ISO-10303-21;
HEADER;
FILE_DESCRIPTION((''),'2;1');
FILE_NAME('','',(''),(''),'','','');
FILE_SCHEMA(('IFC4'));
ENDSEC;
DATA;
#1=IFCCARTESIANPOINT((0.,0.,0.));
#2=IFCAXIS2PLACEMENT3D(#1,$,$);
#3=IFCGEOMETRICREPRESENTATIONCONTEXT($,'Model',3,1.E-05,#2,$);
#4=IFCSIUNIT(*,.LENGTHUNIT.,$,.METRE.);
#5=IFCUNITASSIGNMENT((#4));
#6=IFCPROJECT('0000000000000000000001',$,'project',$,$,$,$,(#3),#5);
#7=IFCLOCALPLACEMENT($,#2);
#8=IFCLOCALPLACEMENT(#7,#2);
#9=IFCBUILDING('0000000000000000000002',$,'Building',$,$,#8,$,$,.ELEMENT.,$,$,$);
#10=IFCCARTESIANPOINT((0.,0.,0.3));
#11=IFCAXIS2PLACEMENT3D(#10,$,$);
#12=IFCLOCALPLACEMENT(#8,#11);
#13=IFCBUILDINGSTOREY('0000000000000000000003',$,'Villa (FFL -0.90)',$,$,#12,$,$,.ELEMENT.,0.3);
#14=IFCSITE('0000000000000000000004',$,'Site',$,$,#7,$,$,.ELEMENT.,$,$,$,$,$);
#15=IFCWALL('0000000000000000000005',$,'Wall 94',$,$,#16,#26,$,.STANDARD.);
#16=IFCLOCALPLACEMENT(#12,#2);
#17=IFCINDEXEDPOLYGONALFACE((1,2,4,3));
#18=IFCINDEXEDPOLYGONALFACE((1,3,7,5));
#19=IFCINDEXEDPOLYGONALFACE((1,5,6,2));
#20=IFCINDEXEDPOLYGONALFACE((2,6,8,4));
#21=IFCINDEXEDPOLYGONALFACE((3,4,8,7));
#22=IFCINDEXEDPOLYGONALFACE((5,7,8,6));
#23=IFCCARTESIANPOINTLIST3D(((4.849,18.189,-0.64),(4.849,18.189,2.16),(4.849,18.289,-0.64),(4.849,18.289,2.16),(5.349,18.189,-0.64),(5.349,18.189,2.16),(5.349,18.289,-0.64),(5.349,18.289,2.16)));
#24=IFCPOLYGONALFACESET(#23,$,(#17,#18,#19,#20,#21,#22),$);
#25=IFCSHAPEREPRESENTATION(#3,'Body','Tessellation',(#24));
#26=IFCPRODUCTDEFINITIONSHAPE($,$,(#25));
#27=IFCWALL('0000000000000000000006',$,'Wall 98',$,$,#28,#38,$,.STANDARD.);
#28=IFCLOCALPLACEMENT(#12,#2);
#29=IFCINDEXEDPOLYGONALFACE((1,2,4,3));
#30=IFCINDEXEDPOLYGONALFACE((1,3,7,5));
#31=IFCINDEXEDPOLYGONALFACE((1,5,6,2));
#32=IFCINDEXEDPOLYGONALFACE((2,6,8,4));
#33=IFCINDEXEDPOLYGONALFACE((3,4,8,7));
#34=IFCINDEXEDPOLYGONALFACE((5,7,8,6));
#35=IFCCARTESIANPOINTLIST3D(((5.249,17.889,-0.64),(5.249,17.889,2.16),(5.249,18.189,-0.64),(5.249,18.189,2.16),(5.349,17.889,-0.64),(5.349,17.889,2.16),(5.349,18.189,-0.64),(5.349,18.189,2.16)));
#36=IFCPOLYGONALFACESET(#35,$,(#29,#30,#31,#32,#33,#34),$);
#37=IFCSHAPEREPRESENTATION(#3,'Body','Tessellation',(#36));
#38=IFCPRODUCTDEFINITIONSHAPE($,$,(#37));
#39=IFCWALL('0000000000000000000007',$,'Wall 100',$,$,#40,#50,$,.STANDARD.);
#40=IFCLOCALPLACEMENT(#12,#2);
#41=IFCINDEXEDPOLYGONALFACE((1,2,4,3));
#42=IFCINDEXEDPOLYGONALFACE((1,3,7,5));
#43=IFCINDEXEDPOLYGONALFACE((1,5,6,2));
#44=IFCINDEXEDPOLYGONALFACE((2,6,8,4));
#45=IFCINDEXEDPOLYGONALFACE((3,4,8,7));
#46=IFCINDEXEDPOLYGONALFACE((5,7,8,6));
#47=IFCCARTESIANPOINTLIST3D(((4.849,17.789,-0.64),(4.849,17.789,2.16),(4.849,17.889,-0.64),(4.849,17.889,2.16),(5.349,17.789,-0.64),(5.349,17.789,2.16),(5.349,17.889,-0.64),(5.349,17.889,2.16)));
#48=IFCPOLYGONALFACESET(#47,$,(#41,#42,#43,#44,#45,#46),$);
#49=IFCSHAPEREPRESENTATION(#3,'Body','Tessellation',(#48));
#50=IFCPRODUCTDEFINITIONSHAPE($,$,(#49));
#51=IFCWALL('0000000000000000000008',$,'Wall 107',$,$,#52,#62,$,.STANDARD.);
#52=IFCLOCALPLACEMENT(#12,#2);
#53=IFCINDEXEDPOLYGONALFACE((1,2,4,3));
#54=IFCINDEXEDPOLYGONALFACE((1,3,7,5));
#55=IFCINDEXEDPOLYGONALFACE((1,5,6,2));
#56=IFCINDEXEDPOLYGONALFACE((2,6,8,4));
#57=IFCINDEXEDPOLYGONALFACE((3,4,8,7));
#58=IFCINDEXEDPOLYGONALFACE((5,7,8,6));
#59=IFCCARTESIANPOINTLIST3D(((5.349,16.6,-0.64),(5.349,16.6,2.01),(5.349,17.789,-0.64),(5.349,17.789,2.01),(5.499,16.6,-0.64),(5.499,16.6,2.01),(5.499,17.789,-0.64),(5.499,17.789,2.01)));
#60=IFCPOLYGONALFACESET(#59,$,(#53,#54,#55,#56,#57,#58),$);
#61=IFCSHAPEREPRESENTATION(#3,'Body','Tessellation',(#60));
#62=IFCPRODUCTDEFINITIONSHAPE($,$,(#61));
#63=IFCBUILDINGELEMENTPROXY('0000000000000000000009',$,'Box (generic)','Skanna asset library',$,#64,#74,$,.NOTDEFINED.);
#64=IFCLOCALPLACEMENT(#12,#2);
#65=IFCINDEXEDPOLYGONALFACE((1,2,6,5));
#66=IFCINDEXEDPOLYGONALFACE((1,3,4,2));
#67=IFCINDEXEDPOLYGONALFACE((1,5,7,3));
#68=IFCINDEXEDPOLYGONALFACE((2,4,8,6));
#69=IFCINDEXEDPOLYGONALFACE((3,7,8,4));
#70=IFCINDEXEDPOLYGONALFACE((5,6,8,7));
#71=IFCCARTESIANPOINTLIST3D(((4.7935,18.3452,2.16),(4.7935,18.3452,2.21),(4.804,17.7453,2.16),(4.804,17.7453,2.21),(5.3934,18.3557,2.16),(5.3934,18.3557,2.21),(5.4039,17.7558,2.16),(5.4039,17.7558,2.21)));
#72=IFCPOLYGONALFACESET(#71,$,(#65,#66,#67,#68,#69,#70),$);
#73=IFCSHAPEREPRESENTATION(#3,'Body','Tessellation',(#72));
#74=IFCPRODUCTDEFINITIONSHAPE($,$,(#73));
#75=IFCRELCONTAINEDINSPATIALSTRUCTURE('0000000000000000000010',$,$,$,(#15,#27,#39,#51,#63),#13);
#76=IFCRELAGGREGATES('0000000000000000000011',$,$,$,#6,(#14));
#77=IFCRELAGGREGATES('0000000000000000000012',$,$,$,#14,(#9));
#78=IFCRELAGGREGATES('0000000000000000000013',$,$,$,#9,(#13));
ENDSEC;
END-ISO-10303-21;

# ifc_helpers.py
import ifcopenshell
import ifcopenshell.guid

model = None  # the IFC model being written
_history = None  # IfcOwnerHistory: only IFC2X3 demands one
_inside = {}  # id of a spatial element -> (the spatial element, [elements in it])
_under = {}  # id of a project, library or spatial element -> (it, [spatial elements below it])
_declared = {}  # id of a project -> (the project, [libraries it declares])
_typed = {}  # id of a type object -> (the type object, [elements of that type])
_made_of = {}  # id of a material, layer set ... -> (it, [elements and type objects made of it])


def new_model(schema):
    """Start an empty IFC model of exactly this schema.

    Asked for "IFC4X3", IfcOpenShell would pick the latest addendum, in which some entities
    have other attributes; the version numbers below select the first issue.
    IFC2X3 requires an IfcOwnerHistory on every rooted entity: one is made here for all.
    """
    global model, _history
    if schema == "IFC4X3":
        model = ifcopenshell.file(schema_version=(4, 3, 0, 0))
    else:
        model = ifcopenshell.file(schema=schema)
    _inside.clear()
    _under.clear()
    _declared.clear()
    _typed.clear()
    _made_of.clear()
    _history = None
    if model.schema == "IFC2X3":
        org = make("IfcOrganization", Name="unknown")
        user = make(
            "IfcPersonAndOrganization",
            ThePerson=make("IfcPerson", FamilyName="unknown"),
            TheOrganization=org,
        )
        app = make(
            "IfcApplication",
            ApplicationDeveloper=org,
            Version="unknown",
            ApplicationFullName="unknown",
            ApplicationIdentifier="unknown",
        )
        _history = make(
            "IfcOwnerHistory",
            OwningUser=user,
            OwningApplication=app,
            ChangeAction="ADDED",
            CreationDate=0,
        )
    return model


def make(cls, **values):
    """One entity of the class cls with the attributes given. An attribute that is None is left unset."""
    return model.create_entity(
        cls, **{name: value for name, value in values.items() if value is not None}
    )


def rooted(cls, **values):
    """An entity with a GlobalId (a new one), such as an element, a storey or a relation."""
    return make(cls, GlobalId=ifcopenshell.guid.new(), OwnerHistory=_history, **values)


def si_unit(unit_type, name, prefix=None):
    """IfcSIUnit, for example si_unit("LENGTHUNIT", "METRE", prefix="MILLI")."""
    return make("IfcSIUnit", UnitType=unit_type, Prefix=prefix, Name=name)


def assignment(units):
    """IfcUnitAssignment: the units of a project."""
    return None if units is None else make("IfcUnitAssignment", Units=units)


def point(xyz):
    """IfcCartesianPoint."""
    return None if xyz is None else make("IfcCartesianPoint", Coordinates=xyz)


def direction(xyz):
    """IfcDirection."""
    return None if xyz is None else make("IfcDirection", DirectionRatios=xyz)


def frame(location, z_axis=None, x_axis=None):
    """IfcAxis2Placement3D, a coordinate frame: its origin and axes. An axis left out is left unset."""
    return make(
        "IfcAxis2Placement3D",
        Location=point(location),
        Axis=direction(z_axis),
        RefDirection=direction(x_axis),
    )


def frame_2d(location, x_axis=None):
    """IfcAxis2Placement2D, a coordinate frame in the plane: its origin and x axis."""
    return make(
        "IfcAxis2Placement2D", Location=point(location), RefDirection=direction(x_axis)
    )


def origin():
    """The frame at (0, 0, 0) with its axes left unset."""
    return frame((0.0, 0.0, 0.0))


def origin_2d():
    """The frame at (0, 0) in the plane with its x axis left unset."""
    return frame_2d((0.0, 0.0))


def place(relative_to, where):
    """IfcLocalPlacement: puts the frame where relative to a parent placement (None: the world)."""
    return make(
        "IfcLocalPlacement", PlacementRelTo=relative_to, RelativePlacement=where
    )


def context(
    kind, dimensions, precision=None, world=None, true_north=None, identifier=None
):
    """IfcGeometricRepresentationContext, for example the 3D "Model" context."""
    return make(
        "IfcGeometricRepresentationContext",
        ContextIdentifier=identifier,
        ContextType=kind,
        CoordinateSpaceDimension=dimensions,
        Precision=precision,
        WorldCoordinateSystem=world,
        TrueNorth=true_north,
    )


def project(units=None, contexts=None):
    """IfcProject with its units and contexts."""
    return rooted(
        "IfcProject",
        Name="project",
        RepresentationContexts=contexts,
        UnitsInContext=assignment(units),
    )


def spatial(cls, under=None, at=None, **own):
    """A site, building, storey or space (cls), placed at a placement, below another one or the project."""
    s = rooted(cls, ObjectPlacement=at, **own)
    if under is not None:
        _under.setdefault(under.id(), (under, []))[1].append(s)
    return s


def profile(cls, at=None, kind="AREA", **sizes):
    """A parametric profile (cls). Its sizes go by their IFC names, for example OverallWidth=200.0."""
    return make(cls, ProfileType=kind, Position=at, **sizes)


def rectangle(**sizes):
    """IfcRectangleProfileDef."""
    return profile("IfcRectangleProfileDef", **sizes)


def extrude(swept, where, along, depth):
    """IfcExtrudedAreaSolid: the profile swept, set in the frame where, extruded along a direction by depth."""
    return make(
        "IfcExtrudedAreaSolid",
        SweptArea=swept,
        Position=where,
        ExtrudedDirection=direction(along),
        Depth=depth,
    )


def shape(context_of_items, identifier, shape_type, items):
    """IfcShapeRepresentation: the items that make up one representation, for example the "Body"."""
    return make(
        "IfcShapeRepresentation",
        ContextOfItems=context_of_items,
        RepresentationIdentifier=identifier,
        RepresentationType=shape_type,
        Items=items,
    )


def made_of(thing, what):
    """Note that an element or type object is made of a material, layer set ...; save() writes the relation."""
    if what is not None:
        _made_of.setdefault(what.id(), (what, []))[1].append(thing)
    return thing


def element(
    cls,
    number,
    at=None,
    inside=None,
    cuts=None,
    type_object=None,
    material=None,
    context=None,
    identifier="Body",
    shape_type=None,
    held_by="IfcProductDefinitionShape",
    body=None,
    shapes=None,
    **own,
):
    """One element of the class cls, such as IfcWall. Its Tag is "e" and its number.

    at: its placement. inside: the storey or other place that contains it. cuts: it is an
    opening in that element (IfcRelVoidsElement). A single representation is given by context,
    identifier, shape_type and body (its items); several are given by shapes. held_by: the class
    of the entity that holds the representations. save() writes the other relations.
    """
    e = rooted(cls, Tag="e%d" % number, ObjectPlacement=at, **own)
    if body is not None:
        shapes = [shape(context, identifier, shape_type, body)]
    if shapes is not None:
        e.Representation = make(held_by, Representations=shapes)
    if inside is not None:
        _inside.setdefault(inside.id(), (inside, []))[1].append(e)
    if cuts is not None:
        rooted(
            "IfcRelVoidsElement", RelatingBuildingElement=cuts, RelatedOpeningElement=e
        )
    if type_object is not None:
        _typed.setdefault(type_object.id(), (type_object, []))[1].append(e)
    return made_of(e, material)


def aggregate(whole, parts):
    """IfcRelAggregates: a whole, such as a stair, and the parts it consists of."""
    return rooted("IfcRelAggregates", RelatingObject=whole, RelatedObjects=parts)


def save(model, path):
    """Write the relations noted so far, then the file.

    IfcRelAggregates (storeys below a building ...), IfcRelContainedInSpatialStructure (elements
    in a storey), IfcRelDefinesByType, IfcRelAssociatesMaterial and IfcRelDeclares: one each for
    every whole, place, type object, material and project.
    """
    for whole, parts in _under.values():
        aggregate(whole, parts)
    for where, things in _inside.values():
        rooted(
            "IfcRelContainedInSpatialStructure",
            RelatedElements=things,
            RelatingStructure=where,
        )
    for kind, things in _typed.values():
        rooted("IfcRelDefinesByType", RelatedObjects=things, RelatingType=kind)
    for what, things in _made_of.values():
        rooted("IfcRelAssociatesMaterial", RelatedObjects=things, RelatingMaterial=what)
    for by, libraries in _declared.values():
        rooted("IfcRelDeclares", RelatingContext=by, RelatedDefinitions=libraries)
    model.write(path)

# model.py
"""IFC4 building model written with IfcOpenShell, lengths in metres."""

from ifc_helpers import new_model, si_unit, frame, frame_2d, origin, origin_2d, place, context, project, spatial, rectangle, extrude, element, save


model = new_model("IFC4")

# Units and contexts
model_context = context("Model", 3, precision=1e-05, world=origin())
ifc_project = project(units=[si_unit("LENGTHUNIT", "METRE")], contexts=[model_context])

# Site, building, storey
site_placement = place(None, origin())
site = spatial("IfcSite", under=ifc_project, at=site_placement, Name="Site", CompositionType="ELEMENT")
building_placement = place(site_placement, origin())
building = spatial("IfcBuilding", under=site, at=building_placement, Name="Building", CompositionType="ELEMENT")
storey_placement = place(building_placement, frame((0.0, 0.0, 0.3)))
storey = spatial("IfcBuildingStorey", under=building, at=storey_placement, Name="Villa (FFL -0.90)", CompositionType="ELEMENT", Elevation=0.3)

# Walls
wall_1_placement = place(storey_placement, frame((5.349, 18.239, -0.64), z_axis=(0.0, 0.0, 1.0), x_axis=(-1.0, 0.0, 0.0)))
element("IfcWall", 1, at=wall_1_placement, inside=storey, Name="Wall 94", PredefinedType="STANDARD", context=model_context, shape_type="SweptSolid", body=[
    extrude(rectangle(XDim=0.5, YDim=0.1, at=frame_2d((0.25, 0.0))), origin(), (0.0, 0.0, 1.0), 2.8),
])
wall_2_placement = place(storey_placement, frame((5.299, 18.189, -0.64), z_axis=(0.0, 0.0, 1.0), x_axis=(0.0, -1.0, 0.0)))
element("IfcWall", 2, at=wall_2_placement, inside=storey, Name="Wall 98", PredefinedType="STANDARD", context=model_context, shape_type="SweptSolid", body=[
    extrude(rectangle(XDim=0.3, YDim=0.1, at=frame_2d((0.15, 0.0))), origin(), (0.0, 0.0, 1.0), 2.8),
])
wall_3_placement = place(storey_placement, frame((5.349, 17.839, -0.64), z_axis=(0.0, 0.0, 1.0), x_axis=(-1.0, 0.0, 0.0)))
element("IfcWall", 3, at=wall_3_placement, inside=storey, Name="Wall 100", PredefinedType="STANDARD", context=model_context, shape_type="SweptSolid", body=[
    extrude(rectangle(XDim=0.5, YDim=0.1, at=frame_2d((0.25, 0.0))), origin(), (0.0, 0.0, 1.0), 2.8),
])
wall_4_placement = place(storey_placement, frame((5.424, 16.6, -0.64), z_axis=(0.0, 0.0, 1.0), x_axis=(0.0, 1.0, 0.0)))
element("IfcWall", 4, at=wall_4_placement, inside=storey, Name="Wall 107", PredefinedType="STANDARD", context=model_context, shape_type="SweptSolid", body=[
    extrude(rectangle(XDim=1.189, YDim=0.15, at=frame_2d((0.5945, 0.0))), origin(), (0.0, 0.0, 1.0), 2.65),
])

# Building element proxy
proxy_placement = place(storey_placement, frame((5.0987, 18.0505, 2.16), z_axis=(0.0, 0.0, 1.0), x_axis=(0.999848, 0.017452, 0.0)))
element("IfcBuildingElementProxy", 5, at=proxy_placement, inside=storey, Name="Box (generic)", Description="Skanna asset library", PredefinedType="NOTDEFINED", context=model_context, shape_type="SweptSolid", body=[
    extrude(rectangle(XDim=0.6, YDim=0.6, at=origin_2d()), origin(), (0.0, 0.0, 1.0), 0.05),
])

save(model, "model.ifc")
